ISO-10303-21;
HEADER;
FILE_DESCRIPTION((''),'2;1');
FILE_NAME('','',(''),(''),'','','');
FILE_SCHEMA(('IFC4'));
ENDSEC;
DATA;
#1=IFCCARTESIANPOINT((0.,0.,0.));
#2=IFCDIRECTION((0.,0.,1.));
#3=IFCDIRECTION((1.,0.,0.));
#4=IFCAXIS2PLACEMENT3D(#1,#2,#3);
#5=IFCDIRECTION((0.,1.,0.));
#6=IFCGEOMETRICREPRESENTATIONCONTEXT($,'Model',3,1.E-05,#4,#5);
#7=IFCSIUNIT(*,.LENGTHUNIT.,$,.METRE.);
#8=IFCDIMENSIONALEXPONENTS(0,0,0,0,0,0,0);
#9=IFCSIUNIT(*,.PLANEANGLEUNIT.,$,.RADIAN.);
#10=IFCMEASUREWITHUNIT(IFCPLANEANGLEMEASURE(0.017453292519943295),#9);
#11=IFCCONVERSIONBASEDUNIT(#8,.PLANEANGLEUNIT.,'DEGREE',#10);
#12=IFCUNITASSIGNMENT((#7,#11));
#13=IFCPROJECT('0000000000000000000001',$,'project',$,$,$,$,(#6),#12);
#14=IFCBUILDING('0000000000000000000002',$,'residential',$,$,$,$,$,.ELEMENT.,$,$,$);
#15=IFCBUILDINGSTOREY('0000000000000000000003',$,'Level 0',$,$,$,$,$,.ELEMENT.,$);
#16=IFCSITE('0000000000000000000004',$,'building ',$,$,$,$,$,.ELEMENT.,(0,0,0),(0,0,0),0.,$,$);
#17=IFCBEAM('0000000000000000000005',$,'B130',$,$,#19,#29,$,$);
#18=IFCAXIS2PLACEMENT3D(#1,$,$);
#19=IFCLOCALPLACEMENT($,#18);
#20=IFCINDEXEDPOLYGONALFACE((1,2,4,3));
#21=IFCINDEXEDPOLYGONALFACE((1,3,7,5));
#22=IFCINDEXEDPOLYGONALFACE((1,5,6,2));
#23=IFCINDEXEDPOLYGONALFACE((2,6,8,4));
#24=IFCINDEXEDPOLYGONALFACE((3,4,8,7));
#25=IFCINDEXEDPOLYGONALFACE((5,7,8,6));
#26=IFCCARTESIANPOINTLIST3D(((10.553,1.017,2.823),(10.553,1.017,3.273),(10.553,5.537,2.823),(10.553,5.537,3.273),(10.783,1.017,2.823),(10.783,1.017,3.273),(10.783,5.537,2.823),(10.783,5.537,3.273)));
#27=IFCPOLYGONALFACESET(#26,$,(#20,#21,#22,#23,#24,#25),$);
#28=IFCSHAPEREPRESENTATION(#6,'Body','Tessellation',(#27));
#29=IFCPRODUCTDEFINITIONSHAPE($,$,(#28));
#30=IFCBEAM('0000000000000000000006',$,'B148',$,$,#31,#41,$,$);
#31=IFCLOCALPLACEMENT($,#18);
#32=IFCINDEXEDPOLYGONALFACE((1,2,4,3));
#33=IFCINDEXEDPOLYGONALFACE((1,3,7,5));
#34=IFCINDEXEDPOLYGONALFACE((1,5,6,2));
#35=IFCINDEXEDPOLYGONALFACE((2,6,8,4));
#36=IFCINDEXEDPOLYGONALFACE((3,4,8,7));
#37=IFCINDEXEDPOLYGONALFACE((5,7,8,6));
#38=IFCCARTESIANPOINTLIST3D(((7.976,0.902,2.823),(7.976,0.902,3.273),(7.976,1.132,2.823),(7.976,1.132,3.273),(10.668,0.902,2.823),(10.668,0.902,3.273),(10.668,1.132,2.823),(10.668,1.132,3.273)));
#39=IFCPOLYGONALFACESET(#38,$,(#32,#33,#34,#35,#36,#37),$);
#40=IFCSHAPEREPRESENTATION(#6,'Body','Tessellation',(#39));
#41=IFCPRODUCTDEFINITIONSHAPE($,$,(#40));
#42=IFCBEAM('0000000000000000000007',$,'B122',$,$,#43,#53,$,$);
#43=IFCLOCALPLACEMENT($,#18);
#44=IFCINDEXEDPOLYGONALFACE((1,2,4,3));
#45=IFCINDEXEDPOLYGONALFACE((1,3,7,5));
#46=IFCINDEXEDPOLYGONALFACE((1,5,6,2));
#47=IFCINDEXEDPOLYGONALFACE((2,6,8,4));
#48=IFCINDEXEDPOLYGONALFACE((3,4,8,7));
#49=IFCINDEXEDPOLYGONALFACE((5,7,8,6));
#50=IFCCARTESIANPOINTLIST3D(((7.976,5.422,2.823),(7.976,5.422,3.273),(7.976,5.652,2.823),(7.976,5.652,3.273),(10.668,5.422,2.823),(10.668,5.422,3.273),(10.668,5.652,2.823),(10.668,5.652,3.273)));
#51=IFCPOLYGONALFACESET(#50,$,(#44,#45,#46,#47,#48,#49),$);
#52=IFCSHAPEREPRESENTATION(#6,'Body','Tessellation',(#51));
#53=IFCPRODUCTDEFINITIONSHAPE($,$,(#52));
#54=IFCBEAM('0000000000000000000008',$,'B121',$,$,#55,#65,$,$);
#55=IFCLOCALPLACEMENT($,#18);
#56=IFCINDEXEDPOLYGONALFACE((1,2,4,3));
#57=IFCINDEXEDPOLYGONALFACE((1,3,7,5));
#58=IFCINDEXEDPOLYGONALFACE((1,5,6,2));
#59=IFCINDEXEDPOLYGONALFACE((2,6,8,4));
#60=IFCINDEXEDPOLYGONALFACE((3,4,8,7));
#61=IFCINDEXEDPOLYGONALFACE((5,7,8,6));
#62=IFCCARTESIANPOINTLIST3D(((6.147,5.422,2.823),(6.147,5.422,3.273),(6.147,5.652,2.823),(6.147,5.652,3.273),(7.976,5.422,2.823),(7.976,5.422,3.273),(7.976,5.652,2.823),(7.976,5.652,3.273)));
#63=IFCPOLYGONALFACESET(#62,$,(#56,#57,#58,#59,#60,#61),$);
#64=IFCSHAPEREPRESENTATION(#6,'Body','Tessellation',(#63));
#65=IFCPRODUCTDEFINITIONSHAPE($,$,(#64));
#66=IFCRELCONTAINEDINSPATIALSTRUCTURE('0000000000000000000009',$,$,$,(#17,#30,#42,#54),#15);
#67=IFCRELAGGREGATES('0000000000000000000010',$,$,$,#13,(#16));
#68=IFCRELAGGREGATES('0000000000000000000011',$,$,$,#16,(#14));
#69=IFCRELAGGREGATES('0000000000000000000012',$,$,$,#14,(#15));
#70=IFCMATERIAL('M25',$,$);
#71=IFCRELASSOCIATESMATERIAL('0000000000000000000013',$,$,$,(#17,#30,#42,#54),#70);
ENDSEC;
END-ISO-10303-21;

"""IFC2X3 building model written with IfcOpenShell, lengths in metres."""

from ifc_helpers import new_model, entity, si_unit, converted_unit, direction, frame, frame_2d, origin_with_axes, place, context, project, spatial, rectangle, extrude, material, element, save


model = new_model("IFC2X3")

# Units and contexts
model_context = context("Model", 3, precision=1e-05, world=origin_with_axes(), true_north=direction((0.0, 1.0, 0.0)))
ifc_project = project(units=[si_unit("LENGTHUNIT", "METRE"), converted_unit("PLANEANGLEUNIT", "DEGREE", entity("IfcPlaneAngleMeasure", 0.017453292519943295), si_unit("PLANEANGLEUNIT", "RADIAN"), dimensions=[0, 0, 0, 0, 0, 0, 0])], contexts=[model_context])

# Site, building, storey
site = spatial("IfcSite", under=ifc_project, Name="building ", CompositionType="ELEMENT", RefLatitude=(0, 0, 0), RefLongitude=(0, 0, 0), RefElevation=0.0)
building = spatial("IfcBuilding", under=site, Name="residential", CompositionType="ELEMENT")
storey = spatial("IfcBuildingStorey", under=building, Name="Level 0", CompositionType="ELEMENT")

# Beams
ifc_material = material(Name="M25")
placement = place(None, origin_with_axes())
element("IfcBeam", 1, at=placement, inside=storey, material=ifc_material, Name="B130", context=model_context, shape_type="SweptSolid", body=[
    extrude(rectangle(XDim=0.23, YDim=0.45, at=frame_2d((0.0, 0.0), x_axis=(0.0, 1.0, 0.0))), frame((10.668, 1.017, 3.048), z_axis=(0.0, 1.0, 0.0), x_axis=(0.0, 0.0, -1.0)), (0.0, 0.0, 1.0), 4.52),
])
element("IfcBeam", 2, at=placement, inside=storey, material=ifc_material, Name="B148", context=model_context, shape_type="SweptSolid", body=[
    extrude(rectangle(XDim=0.23, YDim=0.45, at=frame_2d((0.0, 0.0), x_axis=(0.0, 1.0, 0.0))), frame((7.976, 1.017, 3.048), z_axis=(1.0, 0.0, 0.0), x_axis=(0.0, 0.0, -1.0)), (0.0, 0.0, 1.0), 2.692),
])
element("IfcBeam", 3, at=placement, inside=storey, material=ifc_material, Name="B122", context=model_context, shape_type="SweptSolid", body=[
    extrude(rectangle(XDim=0.23, YDim=0.45, at=frame_2d((0.0, 0.0), x_axis=(0.0, 1.0, 0.0))), frame((7.976, 5.537, 3.048), z_axis=(1.0, 0.0, 0.0), x_axis=(0.0, 0.0, -1.0)), (0.0, 0.0, 1.0), 2.692),
])
element("IfcBeam", 4, at=placement, inside=storey, material=ifc_material, Name="B121", context=model_context, shape_type="SweptSolid", body=[
    extrude(rectangle(XDim=0.23, YDim=0.45, at=frame_2d((0.0, 0.0), x_axis=(0.0, 1.0, 0.0))), frame((6.147, 5.537, 3.048), z_axis=(1.0, 0.0, 0.0), x_axis=(0.0, 0.0, -1.0)), (0.0, 0.0, 1.0), 1.829),
])

save(model, "model.ifc")
